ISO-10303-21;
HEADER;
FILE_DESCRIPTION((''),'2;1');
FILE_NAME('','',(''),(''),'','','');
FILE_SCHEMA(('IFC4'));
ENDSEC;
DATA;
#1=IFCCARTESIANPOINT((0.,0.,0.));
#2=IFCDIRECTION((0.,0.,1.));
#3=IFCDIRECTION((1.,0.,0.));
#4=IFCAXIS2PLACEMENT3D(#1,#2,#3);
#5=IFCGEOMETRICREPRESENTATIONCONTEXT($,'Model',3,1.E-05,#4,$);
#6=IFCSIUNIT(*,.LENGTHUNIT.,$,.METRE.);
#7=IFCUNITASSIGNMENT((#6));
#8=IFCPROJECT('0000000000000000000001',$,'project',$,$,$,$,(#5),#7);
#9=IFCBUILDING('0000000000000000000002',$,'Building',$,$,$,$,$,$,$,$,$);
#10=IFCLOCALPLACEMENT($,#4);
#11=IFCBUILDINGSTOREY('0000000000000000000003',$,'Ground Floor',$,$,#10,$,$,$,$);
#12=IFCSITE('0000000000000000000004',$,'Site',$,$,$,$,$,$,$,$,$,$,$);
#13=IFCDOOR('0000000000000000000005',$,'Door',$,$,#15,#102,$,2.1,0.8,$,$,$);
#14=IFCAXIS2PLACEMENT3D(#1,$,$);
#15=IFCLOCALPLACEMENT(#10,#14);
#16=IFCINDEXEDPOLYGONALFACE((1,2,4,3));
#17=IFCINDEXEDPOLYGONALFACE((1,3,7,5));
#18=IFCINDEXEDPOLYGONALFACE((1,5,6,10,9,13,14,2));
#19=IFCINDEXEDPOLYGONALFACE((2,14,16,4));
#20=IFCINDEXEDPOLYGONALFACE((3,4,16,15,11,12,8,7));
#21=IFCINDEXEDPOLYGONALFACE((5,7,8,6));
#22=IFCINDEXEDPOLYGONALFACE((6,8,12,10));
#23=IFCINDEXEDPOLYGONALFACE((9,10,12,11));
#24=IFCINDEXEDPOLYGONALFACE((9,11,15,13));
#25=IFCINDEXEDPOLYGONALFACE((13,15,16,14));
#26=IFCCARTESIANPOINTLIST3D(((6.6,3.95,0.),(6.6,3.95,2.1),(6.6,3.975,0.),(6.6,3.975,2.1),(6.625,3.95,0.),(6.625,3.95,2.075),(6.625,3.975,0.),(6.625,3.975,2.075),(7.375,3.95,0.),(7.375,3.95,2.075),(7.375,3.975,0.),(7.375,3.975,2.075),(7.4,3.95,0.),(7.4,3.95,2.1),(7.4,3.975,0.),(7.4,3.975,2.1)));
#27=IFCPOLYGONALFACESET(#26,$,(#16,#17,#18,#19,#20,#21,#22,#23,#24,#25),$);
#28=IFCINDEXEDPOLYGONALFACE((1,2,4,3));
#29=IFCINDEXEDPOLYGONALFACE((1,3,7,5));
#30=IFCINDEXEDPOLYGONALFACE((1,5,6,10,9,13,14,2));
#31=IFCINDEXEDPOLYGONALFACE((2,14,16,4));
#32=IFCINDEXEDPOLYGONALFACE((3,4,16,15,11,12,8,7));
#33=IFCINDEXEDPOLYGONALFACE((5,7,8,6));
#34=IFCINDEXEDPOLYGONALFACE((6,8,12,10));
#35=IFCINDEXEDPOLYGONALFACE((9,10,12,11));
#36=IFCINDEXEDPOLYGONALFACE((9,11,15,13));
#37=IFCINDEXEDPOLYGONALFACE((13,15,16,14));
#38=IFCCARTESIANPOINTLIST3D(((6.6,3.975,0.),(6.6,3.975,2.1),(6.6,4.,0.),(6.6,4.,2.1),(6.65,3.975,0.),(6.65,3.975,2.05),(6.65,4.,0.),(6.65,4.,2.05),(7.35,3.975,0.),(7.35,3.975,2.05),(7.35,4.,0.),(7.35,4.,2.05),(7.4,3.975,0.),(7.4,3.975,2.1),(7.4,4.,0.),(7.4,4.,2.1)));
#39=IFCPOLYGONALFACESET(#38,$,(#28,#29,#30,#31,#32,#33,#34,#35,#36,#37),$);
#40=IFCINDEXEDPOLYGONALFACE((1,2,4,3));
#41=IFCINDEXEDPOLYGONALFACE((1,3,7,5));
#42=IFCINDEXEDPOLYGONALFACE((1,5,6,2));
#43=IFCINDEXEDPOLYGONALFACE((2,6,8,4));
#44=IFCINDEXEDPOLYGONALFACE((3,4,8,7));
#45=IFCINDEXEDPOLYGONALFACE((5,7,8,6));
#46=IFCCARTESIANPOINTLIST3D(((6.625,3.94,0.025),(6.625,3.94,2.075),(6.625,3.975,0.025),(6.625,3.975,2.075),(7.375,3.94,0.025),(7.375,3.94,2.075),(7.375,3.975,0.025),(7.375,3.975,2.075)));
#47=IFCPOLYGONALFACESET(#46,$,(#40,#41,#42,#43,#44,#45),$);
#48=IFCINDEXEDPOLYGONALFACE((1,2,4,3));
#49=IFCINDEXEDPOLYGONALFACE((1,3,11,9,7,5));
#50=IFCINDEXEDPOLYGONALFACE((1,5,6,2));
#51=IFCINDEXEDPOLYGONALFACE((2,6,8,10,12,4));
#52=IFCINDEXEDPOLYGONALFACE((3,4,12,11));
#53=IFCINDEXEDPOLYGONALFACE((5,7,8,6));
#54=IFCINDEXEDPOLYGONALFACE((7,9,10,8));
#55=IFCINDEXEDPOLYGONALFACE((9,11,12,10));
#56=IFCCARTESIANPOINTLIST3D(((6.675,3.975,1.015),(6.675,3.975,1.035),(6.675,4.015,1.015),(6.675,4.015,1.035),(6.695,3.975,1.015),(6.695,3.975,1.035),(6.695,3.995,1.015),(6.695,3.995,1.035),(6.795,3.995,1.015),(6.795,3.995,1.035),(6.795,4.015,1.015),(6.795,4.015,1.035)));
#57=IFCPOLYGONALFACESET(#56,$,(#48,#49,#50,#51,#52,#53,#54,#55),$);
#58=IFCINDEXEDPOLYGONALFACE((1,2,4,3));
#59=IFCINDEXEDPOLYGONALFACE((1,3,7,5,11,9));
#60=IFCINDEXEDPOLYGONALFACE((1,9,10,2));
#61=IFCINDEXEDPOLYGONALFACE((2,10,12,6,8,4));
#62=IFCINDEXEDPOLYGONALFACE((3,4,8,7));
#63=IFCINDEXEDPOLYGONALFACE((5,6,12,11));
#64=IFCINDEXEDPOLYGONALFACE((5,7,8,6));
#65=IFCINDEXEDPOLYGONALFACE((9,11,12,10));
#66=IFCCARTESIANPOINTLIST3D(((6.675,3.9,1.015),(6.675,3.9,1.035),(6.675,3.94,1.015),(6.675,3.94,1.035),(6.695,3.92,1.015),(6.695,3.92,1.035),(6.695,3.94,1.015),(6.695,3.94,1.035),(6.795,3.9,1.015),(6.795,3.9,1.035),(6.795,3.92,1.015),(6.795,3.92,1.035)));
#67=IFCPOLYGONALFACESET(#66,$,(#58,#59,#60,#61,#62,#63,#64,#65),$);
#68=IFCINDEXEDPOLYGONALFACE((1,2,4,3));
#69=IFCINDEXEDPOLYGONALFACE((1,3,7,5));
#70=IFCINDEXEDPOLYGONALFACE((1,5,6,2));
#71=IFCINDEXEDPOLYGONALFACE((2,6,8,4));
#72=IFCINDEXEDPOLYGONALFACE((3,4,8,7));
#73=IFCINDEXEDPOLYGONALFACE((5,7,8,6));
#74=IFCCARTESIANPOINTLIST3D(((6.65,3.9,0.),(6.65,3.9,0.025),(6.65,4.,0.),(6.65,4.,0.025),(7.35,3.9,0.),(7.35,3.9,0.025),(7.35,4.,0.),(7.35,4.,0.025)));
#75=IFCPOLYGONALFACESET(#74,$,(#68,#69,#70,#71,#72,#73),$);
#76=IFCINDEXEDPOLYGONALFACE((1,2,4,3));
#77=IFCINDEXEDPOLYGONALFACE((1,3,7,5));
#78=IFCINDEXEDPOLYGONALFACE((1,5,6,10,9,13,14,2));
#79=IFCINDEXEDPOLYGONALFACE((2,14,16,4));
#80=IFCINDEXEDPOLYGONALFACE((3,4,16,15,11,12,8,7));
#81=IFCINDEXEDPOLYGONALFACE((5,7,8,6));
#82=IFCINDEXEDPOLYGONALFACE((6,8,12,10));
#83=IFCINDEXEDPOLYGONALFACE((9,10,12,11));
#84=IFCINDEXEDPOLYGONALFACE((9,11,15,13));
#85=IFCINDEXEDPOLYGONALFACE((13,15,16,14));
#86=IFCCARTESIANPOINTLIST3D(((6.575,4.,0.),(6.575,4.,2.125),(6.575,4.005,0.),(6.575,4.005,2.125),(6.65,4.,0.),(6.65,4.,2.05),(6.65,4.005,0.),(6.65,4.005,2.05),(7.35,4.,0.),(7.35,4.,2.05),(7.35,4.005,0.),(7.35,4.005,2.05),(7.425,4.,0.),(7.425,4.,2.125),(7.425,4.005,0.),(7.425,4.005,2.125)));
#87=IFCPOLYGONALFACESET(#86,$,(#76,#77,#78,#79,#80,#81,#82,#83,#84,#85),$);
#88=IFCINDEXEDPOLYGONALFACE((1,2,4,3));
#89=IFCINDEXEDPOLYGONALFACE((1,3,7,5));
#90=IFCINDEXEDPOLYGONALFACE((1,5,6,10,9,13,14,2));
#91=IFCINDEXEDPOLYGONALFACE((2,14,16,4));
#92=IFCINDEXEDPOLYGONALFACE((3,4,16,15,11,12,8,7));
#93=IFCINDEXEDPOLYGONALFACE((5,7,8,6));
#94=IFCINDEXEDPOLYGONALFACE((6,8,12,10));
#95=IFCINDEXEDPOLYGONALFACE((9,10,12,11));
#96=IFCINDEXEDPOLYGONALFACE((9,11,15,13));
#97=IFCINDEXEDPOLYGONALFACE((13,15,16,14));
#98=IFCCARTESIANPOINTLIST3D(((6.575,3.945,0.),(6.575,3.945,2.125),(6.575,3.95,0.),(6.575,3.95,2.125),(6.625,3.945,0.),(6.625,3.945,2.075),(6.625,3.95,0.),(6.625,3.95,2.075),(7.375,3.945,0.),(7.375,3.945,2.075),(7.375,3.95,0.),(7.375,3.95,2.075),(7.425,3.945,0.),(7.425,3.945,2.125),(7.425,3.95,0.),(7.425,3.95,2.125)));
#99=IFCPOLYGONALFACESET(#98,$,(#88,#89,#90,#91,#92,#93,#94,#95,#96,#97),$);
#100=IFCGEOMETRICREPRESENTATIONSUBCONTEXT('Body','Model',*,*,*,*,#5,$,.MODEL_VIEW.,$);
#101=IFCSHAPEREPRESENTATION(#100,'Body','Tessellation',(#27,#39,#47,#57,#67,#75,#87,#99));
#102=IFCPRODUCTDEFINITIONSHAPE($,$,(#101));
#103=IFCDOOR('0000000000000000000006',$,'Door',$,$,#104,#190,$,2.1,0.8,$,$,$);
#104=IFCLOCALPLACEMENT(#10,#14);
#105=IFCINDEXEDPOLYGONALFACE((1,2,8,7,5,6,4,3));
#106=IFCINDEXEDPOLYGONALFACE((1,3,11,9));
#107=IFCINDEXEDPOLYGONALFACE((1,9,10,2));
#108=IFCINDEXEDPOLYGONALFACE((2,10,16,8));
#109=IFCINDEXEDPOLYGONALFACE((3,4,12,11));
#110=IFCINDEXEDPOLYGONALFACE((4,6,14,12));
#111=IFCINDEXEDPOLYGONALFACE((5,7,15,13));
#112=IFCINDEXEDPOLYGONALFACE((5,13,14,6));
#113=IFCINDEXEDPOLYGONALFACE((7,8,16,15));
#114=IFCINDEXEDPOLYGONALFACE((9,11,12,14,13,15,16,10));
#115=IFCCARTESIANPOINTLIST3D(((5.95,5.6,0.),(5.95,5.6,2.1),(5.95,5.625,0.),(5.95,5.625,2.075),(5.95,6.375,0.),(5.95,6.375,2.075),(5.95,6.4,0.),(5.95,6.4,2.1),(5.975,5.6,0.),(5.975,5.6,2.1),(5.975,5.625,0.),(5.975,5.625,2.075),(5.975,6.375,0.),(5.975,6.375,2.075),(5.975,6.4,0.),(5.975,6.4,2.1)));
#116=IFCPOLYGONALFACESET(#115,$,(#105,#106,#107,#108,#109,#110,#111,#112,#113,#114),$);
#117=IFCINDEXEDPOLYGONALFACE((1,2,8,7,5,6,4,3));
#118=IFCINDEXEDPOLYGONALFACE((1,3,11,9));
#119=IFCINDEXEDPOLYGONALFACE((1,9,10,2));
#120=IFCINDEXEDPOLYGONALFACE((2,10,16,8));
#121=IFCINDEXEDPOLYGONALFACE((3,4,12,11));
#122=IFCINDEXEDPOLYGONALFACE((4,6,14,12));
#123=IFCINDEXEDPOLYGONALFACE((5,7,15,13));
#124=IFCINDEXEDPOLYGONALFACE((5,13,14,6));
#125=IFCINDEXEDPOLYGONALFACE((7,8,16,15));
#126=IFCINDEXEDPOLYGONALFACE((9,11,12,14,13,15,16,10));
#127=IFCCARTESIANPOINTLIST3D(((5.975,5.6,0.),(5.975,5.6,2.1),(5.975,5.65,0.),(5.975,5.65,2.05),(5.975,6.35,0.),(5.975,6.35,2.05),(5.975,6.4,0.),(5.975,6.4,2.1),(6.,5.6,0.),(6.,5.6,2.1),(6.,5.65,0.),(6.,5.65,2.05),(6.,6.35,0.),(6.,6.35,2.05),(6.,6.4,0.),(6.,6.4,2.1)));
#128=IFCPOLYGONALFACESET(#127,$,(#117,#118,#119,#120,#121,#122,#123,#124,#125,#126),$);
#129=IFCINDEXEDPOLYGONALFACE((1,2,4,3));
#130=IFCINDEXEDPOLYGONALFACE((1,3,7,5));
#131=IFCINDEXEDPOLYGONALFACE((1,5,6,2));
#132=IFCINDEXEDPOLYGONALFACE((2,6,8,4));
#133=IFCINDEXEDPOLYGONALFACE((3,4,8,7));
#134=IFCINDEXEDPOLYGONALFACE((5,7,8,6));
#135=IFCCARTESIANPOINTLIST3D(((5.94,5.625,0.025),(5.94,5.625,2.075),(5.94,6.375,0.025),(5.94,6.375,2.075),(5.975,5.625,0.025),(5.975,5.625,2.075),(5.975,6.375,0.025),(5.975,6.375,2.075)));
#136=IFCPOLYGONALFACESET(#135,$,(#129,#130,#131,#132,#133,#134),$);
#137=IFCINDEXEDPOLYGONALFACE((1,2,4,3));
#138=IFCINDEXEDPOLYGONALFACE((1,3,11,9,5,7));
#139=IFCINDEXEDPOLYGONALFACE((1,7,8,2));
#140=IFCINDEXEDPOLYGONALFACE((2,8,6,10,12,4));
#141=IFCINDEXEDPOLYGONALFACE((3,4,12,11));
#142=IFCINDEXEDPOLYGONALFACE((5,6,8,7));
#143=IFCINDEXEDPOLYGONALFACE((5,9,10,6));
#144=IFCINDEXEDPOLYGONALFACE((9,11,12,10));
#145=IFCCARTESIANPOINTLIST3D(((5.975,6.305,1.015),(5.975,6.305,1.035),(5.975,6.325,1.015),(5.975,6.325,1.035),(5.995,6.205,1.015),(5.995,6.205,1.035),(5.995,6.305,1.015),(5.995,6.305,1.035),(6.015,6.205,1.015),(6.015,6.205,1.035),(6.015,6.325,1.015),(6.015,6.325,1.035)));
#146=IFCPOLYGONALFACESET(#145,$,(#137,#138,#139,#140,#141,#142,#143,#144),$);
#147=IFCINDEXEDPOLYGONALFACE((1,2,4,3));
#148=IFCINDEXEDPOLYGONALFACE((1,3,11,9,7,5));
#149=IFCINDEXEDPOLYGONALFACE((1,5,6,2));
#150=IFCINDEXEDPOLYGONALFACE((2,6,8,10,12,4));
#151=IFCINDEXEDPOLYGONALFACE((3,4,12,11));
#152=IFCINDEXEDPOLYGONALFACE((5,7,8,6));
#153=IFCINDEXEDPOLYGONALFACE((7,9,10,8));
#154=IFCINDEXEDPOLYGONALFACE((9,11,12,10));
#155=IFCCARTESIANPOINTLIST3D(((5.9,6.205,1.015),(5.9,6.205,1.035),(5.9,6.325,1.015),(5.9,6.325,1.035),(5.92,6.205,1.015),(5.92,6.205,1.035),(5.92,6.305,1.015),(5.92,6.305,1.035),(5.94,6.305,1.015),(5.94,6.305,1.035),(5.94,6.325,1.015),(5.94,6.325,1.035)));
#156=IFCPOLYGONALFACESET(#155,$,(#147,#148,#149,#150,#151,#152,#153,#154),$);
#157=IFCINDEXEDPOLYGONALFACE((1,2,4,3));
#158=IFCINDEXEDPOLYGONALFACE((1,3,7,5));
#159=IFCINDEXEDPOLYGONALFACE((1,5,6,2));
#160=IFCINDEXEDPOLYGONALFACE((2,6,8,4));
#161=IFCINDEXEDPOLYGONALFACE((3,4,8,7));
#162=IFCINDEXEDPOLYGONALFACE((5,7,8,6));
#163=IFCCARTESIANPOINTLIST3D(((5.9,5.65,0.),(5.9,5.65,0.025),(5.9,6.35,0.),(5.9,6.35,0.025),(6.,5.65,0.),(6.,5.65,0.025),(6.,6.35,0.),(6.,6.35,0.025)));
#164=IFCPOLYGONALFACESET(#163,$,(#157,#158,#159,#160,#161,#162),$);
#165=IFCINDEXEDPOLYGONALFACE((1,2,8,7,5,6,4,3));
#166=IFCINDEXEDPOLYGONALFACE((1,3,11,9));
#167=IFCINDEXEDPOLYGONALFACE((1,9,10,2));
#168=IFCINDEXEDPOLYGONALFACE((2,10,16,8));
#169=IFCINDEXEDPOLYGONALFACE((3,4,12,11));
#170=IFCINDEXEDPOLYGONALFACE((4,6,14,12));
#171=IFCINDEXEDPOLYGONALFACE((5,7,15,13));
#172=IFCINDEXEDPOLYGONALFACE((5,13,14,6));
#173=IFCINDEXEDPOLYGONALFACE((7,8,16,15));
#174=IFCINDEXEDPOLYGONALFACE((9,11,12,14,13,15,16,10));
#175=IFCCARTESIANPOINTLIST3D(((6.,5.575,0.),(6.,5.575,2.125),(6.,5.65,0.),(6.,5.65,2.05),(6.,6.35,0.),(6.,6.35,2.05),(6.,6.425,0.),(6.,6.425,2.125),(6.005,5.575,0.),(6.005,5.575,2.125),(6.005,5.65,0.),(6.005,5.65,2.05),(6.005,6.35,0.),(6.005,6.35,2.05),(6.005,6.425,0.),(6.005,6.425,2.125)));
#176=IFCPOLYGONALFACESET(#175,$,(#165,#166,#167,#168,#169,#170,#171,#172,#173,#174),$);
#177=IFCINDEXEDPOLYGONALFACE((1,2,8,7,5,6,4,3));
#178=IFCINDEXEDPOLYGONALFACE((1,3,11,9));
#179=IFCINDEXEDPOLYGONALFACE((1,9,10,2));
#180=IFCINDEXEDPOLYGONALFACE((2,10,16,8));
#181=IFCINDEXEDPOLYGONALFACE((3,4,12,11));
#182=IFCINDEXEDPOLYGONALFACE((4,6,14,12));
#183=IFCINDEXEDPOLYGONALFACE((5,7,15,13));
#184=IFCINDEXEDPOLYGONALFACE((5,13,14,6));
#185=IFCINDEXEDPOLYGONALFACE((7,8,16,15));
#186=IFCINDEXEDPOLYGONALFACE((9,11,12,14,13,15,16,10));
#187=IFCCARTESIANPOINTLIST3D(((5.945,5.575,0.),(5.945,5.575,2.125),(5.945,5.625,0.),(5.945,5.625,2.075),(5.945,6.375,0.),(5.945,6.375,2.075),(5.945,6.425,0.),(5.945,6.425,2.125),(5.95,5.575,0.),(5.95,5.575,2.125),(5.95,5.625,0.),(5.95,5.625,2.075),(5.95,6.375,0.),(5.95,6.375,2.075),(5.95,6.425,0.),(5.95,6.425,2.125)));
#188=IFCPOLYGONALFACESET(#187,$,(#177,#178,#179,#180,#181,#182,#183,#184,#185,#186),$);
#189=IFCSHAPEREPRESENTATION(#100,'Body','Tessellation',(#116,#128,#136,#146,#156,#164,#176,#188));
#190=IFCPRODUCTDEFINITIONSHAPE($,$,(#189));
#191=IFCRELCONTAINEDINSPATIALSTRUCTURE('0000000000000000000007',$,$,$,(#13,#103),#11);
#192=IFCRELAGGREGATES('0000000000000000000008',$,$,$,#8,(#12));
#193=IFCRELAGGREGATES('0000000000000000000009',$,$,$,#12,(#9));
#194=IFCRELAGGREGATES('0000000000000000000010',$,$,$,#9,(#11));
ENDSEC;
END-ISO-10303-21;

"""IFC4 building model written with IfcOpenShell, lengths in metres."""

from ifc_helpers import new_model, si_unit, frame, origin_with_axes, place, context, subcontext, project, spatial, line, indexed_curve, outline, extrude, element, save


model = new_model("IFC4")

# Units and contexts
model_context = context("Model", 3, precision=1e-05, world=origin_with_axes())
body_context = subcontext(model_context, "Body", "Model", "MODEL_VIEW")
ifc_project = project(units=[si_unit("LENGTHUNIT", "METRE")], contexts=[model_context])

# Site, building, storey
site = spatial("IfcSite", under=ifc_project, Name="Site")
building = spatial("IfcBuilding", under=site, Name="Building")
storey_placement = place(None, origin_with_axes())
storey = spatial("IfcBuildingStorey", under=building, at=storey_placement, Name="Ground Floor")

# Doors
door_1_placement = place(storey_placement, frame((7.4, 4.0, 0.0), z_axis=(0.0, 0.0, 1.0), x_axis=(-1.0, 0.0, 0.0)))
element("IfcDoor", 1, at=door_1_placement, inside=storey, Name="Door", OverallHeight=2.1, OverallWidth=0.8, context=body_context, shape_type="SweptSolid", body=[
    extrude(outline(indexed_curve([(0.0, 0.0), (0.0, 2.1), (0.8, 2.1), (0.8, 0.0), (0.775, 0.0), (0.775, 2.075), (0.025, 2.075), (0.025, 0.0)], segments=[line(1, 2, 3, 4, 5, 6, 7, 8, 1)])), frame((0.0, 0.025, 0.0), z_axis=(0.0, -1.0, 0.0), x_axis=(1.0, 0.0, 0.0)), (0.0, 0.0, -1.0), 0.025),
    extrude(outline(indexed_curve([(0.0, 0.0), (0.0, 2.1), (0.8, 2.1), (0.8, 0.0), (0.75, 0.0), (0.75, 2.05), (0.05, 2.05), (0.05, 0.0)], segments=[line(1, 2, 3, 4, 5, 6, 7, 8, 1)])), frame((0.0, 0.0, 0.0), z_axis=(0.0, -1.0, 0.0), x_axis=(1.0, 0.0, 0.0)), (0.0, 0.0, -1.0), 0.025),
    extrude(outline(indexed_curve([(0.0, 0.0), (0.75, 0.0), (0.75, 0.035), (0.0, 0.035)], segments=[line(1, 2, 3, 4, 1)])), frame((0.025, 0.025, 0.025), z_axis=(0.0, 0.0, 1.0), x_axis=(1.0, 0.0, 0.0)), (0.0, 0.0, 1.0), 2.05),
    extrude(outline(indexed_curve([(0.0, 0.0), (0.0, -0.04), (-0.12, -0.04), (-0.12, -0.02), (-0.02, -0.02), (-0.02, 0.0)], segments=[line(1, 2, 3, 4, 5, 6, 1)])), frame((0.725, 0.025, 1.015), z_axis=(0.0, 0.0, 1.0), x_axis=(1.0, 0.0, 0.0)), (0.0, 0.0, 1.0), 0.02),
    extrude(outline(indexed_curve([(0.0, 0.0), (0.0, 0.04), (-0.12, 0.04), (-0.12, 0.02), (-0.02, 0.02), (-0.02, 0.0)], segments=[line(1, 2, 3, 4, 5, 6, 1)])), frame((0.725, 0.06, 1.015), z_axis=(0.0, 0.0, 1.0), x_axis=(1.0, 0.0, 0.0)), (0.0, 0.0, 1.0), 0.02),
    extrude(outline(indexed_curve([(0.0, 0.0), (0.7, 0.0), (0.7, 0.1), (0.0, 0.1)], segments=[line(1, 2, 3, 4, 1)])), frame((0.05, 0.0, 0.0), z_axis=(0.0, 0.0, 1.0), x_axis=(1.0, 0.0, 0.0)), (0.0, 0.0, 1.0), 0.025),
    extrude(outline(indexed_curve([(0.0, 0.0), (0.0, 2.125), (0.85, 2.125), (0.85, 0.0), (0.775, 0.0), (0.775, 2.05), (0.075, 2.05), (0.075, 0.0)], segments=[line(1, 2, 3, 4, 5, 6, 7, 8, 1)])), frame((-0.025, -0.005, 0.0), z_axis=(0.0, -1.0, 0.0), x_axis=(1.0, 0.0, 0.0)), (0.0, 0.0, -1.0), 0.005),
    extrude(outline(indexed_curve([(0.0, 0.0), (0.0, 2.125), (0.85, 2.125), (0.85, 0.0), (0.8, 0.0), (0.8, 2.075), (0.05, 2.075), (0.05, 0.0)], segments=[line(1, 2, 3, 4, 5, 6, 7, 8, 1)])), frame((-0.025, 0.05, 0.0), z_axis=(0.0, -1.0, 0.0), x_axis=(1.0, 0.0, 0.0)), (0.0, 0.0, -1.0), 0.005),
])
door_2_placement = place(storey_placement, frame((6.0, 5.6, 0.0), z_axis=(0.0, 0.0, 1.0), x_axis=(0.0, 1.0, 0.0)))
element("IfcDoor", 2, at=door_2_placement, inside=storey, Name="Door", OverallHeight=2.1, OverallWidth=0.8, context=body_context, shape_type="SweptSolid", body=[
    extrude(outline(indexed_curve([(0.0, 0.0), (0.0, 2.1), (0.8, 2.1), (0.8, 0.0), (0.775, 0.0), (0.775, 2.075), (0.025, 2.075), (0.025, 0.0)], segments=[line(1, 2, 3, 4, 5, 6, 7, 8, 1)])), frame((0.0, 0.025, 0.0), z_axis=(0.0, -1.0, 0.0), x_axis=(1.0, 0.0, 0.0)), (0.0, 0.0, -1.0), 0.025),
    extrude(outline(indexed_curve([(0.0, 0.0), (0.0, 2.1), (0.8, 2.1), (0.8, 0.0), (0.75, 0.0), (0.75, 2.05), (0.05, 2.05), (0.05, 0.0)], segments=[line(1, 2, 3, 4, 5, 6, 7, 8, 1)])), frame((0.0, 0.0, 0.0), z_axis=(0.0, -1.0, 0.0), x_axis=(1.0, 0.0, 0.0)), (0.0, 0.0, -1.0), 0.025),
    extrude(outline(indexed_curve([(0.0, 0.0), (0.75, 0.0), (0.75, 0.035), (0.0, 0.035)], segments=[line(1, 2, 3, 4, 1)])), frame((0.025, 0.025, 0.025), z_axis=(0.0, 0.0, 1.0), x_axis=(1.0, 0.0, 0.0)), (0.0, 0.0, 1.0), 2.05),
    extrude(outline(indexed_curve([(0.0, 0.0), (0.0, -0.04), (-0.12, -0.04), (-0.12, -0.02), (-0.02, -0.02), (-0.02, 0.0)], segments=[line(1, 2, 3, 4, 5, 6, 1)])), frame((0.725, 0.025, 1.015), z_axis=(0.0, 0.0, 1.0), x_axis=(1.0, 0.0, 0.0)), (0.0, 0.0, 1.0), 0.02),
    extrude(outline(indexed_curve([(0.0, 0.0), (0.0, 0.04), (-0.12, 0.04), (-0.12, 0.02), (-0.02, 0.02), (-0.02, 0.0)], segments=[line(1, 2, 3, 4, 5, 6, 1)])), frame((0.725, 0.06, 1.015), z_axis=(0.0, 0.0, 1.0), x_axis=(1.0, 0.0, 0.0)), (0.0, 0.0, 1.0), 0.02),
    extrude(outline(indexed_curve([(0.0, 0.0), (0.7, 0.0), (0.7, 0.1), (0.0, 0.1)], segments=[line(1, 2, 3, 4, 1)])), frame((0.05, 0.0, 0.0), z_axis=(0.0, 0.0, 1.0), x_axis=(1.0, 0.0, 0.0)), (0.0, 0.0, 1.0), 0.025),
    extrude(outline(indexed_curve([(0.0, 0.0), (0.0, 2.125), (0.85, 2.125), (0.85, 0.0), (0.775, 0.0), (0.775, 2.05), (0.075, 2.05), (0.075, 0.0)], segments=[line(1, 2, 3, 4, 5, 6, 7, 8, 1)])), frame((-0.025, -0.005, 0.0), z_axis=(0.0, -1.0, 0.0), x_axis=(1.0, 0.0, 0.0)), (0.0, 0.0, -1.0), 0.005),
    extrude(outline(indexed_curve([(0.0, 0.0), (0.0, 2.125), (0.85, 2.125), (0.85, 0.0), (0.8, 0.0), (0.8, 2.075), (0.05, 2.075), (0.05, 0.0)], segments=[line(1, 2, 3, 4, 5, 6, 7, 8, 1)])), frame((-0.025, 0.05, 0.0), z_axis=(0.0, -1.0, 0.0), x_axis=(1.0, 0.0, 0.0)), (0.0, 0.0, -1.0), 0.005),
])

save(model, "model.ifc")
